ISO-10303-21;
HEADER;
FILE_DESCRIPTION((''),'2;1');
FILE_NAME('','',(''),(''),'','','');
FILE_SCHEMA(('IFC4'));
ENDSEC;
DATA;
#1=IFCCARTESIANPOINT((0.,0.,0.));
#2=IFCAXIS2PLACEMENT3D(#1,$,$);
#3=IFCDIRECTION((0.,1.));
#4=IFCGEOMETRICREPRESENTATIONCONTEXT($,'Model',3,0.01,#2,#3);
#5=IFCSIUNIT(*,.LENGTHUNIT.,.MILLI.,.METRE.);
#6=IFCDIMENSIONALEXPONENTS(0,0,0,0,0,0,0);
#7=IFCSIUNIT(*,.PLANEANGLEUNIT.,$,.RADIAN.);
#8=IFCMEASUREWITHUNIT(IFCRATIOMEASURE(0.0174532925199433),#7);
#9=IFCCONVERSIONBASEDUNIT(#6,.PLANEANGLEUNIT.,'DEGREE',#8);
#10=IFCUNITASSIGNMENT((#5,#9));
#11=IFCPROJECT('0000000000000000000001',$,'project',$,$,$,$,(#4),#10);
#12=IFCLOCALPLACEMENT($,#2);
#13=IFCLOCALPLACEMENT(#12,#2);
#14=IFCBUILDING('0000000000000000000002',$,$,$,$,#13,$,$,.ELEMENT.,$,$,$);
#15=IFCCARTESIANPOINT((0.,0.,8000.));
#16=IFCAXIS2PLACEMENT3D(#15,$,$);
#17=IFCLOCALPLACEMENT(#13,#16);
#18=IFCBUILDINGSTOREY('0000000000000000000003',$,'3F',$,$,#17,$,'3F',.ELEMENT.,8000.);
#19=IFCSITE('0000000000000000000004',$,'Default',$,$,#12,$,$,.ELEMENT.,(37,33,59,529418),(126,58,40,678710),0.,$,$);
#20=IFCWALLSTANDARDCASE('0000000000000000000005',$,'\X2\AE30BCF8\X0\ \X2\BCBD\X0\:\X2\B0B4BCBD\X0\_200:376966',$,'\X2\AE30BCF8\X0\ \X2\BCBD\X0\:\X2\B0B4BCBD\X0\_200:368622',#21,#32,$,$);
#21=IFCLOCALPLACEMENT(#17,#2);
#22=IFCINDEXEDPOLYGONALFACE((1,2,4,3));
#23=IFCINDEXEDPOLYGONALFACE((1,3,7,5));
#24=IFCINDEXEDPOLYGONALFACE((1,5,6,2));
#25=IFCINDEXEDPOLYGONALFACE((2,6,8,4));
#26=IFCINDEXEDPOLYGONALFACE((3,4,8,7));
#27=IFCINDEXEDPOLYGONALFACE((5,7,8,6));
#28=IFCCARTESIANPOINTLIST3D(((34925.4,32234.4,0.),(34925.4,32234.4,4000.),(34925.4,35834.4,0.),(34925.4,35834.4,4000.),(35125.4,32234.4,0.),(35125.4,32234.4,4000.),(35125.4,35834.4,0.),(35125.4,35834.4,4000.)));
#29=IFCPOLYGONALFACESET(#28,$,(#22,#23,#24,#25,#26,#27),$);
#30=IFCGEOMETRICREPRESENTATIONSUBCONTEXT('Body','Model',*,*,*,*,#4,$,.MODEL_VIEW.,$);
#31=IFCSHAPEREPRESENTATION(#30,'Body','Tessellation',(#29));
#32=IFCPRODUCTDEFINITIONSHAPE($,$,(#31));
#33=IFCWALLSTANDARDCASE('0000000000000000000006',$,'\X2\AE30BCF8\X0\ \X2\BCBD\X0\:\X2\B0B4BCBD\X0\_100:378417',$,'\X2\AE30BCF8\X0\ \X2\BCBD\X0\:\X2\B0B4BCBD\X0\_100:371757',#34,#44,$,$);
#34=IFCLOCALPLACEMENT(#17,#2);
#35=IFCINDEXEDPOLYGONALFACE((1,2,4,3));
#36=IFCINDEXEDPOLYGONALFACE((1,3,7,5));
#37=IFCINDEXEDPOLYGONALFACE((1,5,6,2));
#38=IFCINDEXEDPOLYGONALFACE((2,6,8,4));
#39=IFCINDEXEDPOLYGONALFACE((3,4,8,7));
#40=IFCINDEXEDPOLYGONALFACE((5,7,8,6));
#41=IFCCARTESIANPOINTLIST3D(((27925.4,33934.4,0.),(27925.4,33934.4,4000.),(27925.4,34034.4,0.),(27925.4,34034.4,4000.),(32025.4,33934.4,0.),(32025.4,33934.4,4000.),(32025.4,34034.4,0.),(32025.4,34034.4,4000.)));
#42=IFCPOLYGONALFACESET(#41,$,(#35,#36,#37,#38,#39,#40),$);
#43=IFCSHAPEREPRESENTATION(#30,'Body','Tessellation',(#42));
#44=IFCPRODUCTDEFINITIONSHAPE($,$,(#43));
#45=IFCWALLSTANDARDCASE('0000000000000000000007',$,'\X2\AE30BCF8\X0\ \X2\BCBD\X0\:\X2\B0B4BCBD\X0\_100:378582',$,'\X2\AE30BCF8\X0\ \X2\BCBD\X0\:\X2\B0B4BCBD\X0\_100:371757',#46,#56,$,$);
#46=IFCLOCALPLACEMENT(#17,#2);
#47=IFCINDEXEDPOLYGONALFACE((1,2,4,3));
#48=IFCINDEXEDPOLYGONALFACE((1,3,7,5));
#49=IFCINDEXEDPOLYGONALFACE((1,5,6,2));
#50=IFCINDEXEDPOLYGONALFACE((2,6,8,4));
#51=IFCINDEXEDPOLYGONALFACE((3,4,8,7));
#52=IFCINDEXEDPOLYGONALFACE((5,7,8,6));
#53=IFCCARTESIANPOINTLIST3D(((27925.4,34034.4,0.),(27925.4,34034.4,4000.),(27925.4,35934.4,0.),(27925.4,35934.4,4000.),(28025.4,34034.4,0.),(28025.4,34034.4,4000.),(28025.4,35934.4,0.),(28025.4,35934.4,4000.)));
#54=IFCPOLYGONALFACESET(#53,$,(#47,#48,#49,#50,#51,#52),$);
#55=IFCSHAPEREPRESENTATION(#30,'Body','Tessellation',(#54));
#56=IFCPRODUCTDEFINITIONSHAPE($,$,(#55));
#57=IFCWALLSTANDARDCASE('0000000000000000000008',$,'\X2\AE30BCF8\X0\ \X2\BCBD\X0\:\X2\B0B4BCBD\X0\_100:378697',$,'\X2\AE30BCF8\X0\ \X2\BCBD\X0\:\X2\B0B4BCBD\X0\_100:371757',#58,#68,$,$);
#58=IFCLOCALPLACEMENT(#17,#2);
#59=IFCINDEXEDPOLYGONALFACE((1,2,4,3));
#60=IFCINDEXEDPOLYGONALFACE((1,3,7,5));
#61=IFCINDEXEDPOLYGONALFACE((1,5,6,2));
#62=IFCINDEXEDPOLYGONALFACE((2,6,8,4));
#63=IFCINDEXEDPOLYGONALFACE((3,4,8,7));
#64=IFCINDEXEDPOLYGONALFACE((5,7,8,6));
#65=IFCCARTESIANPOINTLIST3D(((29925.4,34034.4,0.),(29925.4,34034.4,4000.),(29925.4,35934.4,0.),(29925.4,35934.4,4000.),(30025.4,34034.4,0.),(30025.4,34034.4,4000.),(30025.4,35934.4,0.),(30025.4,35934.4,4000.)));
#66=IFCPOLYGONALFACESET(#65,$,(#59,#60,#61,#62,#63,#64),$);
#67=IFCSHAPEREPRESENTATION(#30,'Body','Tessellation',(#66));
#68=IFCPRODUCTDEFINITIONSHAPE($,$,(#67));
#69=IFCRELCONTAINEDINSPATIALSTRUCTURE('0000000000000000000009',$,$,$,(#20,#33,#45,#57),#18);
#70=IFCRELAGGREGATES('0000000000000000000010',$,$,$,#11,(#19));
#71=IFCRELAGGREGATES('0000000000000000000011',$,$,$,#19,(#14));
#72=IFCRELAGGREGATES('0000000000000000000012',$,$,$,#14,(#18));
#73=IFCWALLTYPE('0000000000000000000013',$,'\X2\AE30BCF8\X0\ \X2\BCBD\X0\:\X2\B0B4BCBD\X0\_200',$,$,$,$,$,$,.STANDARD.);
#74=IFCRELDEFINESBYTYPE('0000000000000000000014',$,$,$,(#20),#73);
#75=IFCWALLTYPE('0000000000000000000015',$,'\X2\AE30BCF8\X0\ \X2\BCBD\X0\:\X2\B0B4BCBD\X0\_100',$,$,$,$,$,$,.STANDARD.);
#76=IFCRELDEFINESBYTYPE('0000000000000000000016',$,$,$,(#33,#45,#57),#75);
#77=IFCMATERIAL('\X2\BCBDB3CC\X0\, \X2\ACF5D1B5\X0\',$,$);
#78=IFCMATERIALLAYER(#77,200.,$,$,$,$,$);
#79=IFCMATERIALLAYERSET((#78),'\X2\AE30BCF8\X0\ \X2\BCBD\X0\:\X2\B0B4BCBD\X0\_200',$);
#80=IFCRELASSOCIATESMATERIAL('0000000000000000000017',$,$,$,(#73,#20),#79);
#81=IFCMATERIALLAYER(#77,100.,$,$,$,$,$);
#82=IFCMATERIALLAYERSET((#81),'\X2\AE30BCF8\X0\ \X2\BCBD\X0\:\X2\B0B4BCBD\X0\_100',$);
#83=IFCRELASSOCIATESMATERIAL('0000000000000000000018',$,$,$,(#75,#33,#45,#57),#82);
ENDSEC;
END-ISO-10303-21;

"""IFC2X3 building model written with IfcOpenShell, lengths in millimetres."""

from ifc_helpers import new_model, entity, si_unit, converted_unit, direction, frame, frame_2d, origin, place, context, subcontext, project, spatial, rectangle, extrude, material, layer, layer_set, layer_usage, type_object, element, save


model = new_model("IFC2X3")

# Units and contexts
model_context = context("Model", 3, precision=0.01, world=origin(), true_north=direction((0.0, 1.0)))
body_context = subcontext(model_context, "Body", "Model", "MODEL_VIEW")
ifc_project = project(units=[si_unit("LENGTHUNIT", "METRE", prefix="MILLI"), converted_unit("PLANEANGLEUNIT", "DEGREE", entity("IfcRatioMeasure", 0.0174532925199433), si_unit("PLANEANGLEUNIT", "RADIAN"), dimensions=[0, 0, 0, 0, 0, 0, 0])], contexts=[model_context])

# Site, building, storey
site_placement = place(None, origin())
site = spatial("IfcSite", under=ifc_project, at=site_placement, Name="Default", CompositionType="ELEMENT", RefLatitude=(37, 33, 59, 529418), RefLongitude=(126, 58, 40, 678710), RefElevation=0.0)
building_placement = place(site_placement, origin())
building = spatial("IfcBuilding", under=site, at=building_placement, CompositionType="ELEMENT")
storey_placement = place(building_placement, frame((0.0, 0.0, 8000.0)))
storey = spatial("IfcBuildingStorey", under=building, at=storey_placement, Name="3F", LongName="3F", CompositionType="ELEMENT", Elevation=8000.0)

# Walls
ifc_material_1 = material(Name="벽돌, 공통")
ifc_layer_1 = layer(ifc_material_1, 200.0)
ifc_layer_set_1 = layer_set([ifc_layer_1], Name="기본 벽:내벽_200")
wall_type_1 = type_object("IfcWallType", Name="기본 벽:내벽_200", PredefinedType="STANDARD", material=ifc_layer_set_1)
ifc_layer_usage_1 = layer_usage(ifc_layer_set_1, "AXIS2", "NEGATIVE", 100.0)
wall_1_placement = place(storey_placement, frame((35025.4, 35834.4, 0.0), z_axis=(0.0, 0.0, 1.0), x_axis=(0.0, -1.0, 0.0)))
element("IfcWallStandardCase", 1, at=wall_1_placement, inside=storey, type_object=wall_type_1, material=ifc_layer_usage_1, Name="기본 벽:내벽_200:376966", ObjectType="기본 벽:내벽_200:368622", context=body_context, shape_type="SweptSolid", body=[
    extrude(rectangle(XDim=3600.0, YDim=200.0, at=frame_2d((1800.0, 0.0), x_axis=(-1.0, 0.0))), origin(), (0.0, 0.0, 1.0), 4000.0),
])
ifc_layer_2 = layer(ifc_material_1, 100.0)
ifc_layer_set_2 = layer_set([ifc_layer_2], Name="기본 벽:내벽_100")
ifc_layer_usage_2 = layer_usage(ifc_layer_set_2, "AXIS2", "NEGATIVE", 50.0)
wall_type_2 = type_object("IfcWallType", Name="기본 벽:내벽_100", PredefinedType="STANDARD", material=ifc_layer_set_2)
wall_2_placement = place(storey_placement, frame((32025.4, 33984.4, 0.0), z_axis=(0.0, 0.0, 1.0), x_axis=(-1.0, 0.0, 0.0)))
element("IfcWallStandardCase", 2, at=wall_2_placement, inside=storey, type_object=wall_type_2, material=ifc_layer_usage_2, Name="기본 벽:내벽_100:378417", ObjectType="기본 벽:내벽_100:371757", context=body_context, shape_type="SweptSolid", body=[
    extrude(rectangle(XDim=4100.0, YDim=100.0, at=frame_2d((2050.0, 0.0), x_axis=(-1.0, 0.0))), origin(), (0.0, 0.0, 1.0), 4000.0),
])
ifc_layer_usage_3 = layer_usage(ifc_layer_set_2, "AXIS2", "NEGATIVE", 50.0)
wall_3_placement = place(storey_placement, frame((27975.4, 35934.4, 0.0), z_axis=(0.0, 0.0, 1.0), x_axis=(0.0, -1.0, 0.0)))
element("IfcWallStandardCase", 3, at=wall_3_placement, inside=storey, type_object=wall_type_2, material=ifc_layer_usage_3, Name="기본 벽:내벽_100:378582", ObjectType="기본 벽:내벽_100:371757", context=body_context, shape_type="SweptSolid", body=[
    extrude(rectangle(XDim=1900.0, YDim=100.0, at=frame_2d((950.0, 0.0), x_axis=(-1.0, 0.0))), origin(), (0.0, 0.0, 1.0), 4000.0),
])
ifc_layer_usage_4 = layer_usage(ifc_layer_set_2, "AXIS2", "NEGATIVE", 50.0)
wall_4_placement = place(storey_placement, frame((29975.4, 35934.4, 0.0), z_axis=(0.0, 0.0, 1.0), x_axis=(0.0, -1.0, 0.0)))
element("IfcWallStandardCase", 4, at=wall_4_placement, inside=storey, type_object=wall_type_2, material=ifc_layer_usage_4, Name="기본 벽:내벽_100:378697", ObjectType="기본 벽:내벽_100:371757", context=body_context, shape_type="SweptSolid", body=[
    extrude(rectangle(XDim=1900.0, YDim=100.0, at=frame_2d((950.0, 0.0), x_axis=(-1.0, 0.0))), origin(), (0.0, 0.0, 1.0), 4000.0),
])

save(model, "model.ifc")
